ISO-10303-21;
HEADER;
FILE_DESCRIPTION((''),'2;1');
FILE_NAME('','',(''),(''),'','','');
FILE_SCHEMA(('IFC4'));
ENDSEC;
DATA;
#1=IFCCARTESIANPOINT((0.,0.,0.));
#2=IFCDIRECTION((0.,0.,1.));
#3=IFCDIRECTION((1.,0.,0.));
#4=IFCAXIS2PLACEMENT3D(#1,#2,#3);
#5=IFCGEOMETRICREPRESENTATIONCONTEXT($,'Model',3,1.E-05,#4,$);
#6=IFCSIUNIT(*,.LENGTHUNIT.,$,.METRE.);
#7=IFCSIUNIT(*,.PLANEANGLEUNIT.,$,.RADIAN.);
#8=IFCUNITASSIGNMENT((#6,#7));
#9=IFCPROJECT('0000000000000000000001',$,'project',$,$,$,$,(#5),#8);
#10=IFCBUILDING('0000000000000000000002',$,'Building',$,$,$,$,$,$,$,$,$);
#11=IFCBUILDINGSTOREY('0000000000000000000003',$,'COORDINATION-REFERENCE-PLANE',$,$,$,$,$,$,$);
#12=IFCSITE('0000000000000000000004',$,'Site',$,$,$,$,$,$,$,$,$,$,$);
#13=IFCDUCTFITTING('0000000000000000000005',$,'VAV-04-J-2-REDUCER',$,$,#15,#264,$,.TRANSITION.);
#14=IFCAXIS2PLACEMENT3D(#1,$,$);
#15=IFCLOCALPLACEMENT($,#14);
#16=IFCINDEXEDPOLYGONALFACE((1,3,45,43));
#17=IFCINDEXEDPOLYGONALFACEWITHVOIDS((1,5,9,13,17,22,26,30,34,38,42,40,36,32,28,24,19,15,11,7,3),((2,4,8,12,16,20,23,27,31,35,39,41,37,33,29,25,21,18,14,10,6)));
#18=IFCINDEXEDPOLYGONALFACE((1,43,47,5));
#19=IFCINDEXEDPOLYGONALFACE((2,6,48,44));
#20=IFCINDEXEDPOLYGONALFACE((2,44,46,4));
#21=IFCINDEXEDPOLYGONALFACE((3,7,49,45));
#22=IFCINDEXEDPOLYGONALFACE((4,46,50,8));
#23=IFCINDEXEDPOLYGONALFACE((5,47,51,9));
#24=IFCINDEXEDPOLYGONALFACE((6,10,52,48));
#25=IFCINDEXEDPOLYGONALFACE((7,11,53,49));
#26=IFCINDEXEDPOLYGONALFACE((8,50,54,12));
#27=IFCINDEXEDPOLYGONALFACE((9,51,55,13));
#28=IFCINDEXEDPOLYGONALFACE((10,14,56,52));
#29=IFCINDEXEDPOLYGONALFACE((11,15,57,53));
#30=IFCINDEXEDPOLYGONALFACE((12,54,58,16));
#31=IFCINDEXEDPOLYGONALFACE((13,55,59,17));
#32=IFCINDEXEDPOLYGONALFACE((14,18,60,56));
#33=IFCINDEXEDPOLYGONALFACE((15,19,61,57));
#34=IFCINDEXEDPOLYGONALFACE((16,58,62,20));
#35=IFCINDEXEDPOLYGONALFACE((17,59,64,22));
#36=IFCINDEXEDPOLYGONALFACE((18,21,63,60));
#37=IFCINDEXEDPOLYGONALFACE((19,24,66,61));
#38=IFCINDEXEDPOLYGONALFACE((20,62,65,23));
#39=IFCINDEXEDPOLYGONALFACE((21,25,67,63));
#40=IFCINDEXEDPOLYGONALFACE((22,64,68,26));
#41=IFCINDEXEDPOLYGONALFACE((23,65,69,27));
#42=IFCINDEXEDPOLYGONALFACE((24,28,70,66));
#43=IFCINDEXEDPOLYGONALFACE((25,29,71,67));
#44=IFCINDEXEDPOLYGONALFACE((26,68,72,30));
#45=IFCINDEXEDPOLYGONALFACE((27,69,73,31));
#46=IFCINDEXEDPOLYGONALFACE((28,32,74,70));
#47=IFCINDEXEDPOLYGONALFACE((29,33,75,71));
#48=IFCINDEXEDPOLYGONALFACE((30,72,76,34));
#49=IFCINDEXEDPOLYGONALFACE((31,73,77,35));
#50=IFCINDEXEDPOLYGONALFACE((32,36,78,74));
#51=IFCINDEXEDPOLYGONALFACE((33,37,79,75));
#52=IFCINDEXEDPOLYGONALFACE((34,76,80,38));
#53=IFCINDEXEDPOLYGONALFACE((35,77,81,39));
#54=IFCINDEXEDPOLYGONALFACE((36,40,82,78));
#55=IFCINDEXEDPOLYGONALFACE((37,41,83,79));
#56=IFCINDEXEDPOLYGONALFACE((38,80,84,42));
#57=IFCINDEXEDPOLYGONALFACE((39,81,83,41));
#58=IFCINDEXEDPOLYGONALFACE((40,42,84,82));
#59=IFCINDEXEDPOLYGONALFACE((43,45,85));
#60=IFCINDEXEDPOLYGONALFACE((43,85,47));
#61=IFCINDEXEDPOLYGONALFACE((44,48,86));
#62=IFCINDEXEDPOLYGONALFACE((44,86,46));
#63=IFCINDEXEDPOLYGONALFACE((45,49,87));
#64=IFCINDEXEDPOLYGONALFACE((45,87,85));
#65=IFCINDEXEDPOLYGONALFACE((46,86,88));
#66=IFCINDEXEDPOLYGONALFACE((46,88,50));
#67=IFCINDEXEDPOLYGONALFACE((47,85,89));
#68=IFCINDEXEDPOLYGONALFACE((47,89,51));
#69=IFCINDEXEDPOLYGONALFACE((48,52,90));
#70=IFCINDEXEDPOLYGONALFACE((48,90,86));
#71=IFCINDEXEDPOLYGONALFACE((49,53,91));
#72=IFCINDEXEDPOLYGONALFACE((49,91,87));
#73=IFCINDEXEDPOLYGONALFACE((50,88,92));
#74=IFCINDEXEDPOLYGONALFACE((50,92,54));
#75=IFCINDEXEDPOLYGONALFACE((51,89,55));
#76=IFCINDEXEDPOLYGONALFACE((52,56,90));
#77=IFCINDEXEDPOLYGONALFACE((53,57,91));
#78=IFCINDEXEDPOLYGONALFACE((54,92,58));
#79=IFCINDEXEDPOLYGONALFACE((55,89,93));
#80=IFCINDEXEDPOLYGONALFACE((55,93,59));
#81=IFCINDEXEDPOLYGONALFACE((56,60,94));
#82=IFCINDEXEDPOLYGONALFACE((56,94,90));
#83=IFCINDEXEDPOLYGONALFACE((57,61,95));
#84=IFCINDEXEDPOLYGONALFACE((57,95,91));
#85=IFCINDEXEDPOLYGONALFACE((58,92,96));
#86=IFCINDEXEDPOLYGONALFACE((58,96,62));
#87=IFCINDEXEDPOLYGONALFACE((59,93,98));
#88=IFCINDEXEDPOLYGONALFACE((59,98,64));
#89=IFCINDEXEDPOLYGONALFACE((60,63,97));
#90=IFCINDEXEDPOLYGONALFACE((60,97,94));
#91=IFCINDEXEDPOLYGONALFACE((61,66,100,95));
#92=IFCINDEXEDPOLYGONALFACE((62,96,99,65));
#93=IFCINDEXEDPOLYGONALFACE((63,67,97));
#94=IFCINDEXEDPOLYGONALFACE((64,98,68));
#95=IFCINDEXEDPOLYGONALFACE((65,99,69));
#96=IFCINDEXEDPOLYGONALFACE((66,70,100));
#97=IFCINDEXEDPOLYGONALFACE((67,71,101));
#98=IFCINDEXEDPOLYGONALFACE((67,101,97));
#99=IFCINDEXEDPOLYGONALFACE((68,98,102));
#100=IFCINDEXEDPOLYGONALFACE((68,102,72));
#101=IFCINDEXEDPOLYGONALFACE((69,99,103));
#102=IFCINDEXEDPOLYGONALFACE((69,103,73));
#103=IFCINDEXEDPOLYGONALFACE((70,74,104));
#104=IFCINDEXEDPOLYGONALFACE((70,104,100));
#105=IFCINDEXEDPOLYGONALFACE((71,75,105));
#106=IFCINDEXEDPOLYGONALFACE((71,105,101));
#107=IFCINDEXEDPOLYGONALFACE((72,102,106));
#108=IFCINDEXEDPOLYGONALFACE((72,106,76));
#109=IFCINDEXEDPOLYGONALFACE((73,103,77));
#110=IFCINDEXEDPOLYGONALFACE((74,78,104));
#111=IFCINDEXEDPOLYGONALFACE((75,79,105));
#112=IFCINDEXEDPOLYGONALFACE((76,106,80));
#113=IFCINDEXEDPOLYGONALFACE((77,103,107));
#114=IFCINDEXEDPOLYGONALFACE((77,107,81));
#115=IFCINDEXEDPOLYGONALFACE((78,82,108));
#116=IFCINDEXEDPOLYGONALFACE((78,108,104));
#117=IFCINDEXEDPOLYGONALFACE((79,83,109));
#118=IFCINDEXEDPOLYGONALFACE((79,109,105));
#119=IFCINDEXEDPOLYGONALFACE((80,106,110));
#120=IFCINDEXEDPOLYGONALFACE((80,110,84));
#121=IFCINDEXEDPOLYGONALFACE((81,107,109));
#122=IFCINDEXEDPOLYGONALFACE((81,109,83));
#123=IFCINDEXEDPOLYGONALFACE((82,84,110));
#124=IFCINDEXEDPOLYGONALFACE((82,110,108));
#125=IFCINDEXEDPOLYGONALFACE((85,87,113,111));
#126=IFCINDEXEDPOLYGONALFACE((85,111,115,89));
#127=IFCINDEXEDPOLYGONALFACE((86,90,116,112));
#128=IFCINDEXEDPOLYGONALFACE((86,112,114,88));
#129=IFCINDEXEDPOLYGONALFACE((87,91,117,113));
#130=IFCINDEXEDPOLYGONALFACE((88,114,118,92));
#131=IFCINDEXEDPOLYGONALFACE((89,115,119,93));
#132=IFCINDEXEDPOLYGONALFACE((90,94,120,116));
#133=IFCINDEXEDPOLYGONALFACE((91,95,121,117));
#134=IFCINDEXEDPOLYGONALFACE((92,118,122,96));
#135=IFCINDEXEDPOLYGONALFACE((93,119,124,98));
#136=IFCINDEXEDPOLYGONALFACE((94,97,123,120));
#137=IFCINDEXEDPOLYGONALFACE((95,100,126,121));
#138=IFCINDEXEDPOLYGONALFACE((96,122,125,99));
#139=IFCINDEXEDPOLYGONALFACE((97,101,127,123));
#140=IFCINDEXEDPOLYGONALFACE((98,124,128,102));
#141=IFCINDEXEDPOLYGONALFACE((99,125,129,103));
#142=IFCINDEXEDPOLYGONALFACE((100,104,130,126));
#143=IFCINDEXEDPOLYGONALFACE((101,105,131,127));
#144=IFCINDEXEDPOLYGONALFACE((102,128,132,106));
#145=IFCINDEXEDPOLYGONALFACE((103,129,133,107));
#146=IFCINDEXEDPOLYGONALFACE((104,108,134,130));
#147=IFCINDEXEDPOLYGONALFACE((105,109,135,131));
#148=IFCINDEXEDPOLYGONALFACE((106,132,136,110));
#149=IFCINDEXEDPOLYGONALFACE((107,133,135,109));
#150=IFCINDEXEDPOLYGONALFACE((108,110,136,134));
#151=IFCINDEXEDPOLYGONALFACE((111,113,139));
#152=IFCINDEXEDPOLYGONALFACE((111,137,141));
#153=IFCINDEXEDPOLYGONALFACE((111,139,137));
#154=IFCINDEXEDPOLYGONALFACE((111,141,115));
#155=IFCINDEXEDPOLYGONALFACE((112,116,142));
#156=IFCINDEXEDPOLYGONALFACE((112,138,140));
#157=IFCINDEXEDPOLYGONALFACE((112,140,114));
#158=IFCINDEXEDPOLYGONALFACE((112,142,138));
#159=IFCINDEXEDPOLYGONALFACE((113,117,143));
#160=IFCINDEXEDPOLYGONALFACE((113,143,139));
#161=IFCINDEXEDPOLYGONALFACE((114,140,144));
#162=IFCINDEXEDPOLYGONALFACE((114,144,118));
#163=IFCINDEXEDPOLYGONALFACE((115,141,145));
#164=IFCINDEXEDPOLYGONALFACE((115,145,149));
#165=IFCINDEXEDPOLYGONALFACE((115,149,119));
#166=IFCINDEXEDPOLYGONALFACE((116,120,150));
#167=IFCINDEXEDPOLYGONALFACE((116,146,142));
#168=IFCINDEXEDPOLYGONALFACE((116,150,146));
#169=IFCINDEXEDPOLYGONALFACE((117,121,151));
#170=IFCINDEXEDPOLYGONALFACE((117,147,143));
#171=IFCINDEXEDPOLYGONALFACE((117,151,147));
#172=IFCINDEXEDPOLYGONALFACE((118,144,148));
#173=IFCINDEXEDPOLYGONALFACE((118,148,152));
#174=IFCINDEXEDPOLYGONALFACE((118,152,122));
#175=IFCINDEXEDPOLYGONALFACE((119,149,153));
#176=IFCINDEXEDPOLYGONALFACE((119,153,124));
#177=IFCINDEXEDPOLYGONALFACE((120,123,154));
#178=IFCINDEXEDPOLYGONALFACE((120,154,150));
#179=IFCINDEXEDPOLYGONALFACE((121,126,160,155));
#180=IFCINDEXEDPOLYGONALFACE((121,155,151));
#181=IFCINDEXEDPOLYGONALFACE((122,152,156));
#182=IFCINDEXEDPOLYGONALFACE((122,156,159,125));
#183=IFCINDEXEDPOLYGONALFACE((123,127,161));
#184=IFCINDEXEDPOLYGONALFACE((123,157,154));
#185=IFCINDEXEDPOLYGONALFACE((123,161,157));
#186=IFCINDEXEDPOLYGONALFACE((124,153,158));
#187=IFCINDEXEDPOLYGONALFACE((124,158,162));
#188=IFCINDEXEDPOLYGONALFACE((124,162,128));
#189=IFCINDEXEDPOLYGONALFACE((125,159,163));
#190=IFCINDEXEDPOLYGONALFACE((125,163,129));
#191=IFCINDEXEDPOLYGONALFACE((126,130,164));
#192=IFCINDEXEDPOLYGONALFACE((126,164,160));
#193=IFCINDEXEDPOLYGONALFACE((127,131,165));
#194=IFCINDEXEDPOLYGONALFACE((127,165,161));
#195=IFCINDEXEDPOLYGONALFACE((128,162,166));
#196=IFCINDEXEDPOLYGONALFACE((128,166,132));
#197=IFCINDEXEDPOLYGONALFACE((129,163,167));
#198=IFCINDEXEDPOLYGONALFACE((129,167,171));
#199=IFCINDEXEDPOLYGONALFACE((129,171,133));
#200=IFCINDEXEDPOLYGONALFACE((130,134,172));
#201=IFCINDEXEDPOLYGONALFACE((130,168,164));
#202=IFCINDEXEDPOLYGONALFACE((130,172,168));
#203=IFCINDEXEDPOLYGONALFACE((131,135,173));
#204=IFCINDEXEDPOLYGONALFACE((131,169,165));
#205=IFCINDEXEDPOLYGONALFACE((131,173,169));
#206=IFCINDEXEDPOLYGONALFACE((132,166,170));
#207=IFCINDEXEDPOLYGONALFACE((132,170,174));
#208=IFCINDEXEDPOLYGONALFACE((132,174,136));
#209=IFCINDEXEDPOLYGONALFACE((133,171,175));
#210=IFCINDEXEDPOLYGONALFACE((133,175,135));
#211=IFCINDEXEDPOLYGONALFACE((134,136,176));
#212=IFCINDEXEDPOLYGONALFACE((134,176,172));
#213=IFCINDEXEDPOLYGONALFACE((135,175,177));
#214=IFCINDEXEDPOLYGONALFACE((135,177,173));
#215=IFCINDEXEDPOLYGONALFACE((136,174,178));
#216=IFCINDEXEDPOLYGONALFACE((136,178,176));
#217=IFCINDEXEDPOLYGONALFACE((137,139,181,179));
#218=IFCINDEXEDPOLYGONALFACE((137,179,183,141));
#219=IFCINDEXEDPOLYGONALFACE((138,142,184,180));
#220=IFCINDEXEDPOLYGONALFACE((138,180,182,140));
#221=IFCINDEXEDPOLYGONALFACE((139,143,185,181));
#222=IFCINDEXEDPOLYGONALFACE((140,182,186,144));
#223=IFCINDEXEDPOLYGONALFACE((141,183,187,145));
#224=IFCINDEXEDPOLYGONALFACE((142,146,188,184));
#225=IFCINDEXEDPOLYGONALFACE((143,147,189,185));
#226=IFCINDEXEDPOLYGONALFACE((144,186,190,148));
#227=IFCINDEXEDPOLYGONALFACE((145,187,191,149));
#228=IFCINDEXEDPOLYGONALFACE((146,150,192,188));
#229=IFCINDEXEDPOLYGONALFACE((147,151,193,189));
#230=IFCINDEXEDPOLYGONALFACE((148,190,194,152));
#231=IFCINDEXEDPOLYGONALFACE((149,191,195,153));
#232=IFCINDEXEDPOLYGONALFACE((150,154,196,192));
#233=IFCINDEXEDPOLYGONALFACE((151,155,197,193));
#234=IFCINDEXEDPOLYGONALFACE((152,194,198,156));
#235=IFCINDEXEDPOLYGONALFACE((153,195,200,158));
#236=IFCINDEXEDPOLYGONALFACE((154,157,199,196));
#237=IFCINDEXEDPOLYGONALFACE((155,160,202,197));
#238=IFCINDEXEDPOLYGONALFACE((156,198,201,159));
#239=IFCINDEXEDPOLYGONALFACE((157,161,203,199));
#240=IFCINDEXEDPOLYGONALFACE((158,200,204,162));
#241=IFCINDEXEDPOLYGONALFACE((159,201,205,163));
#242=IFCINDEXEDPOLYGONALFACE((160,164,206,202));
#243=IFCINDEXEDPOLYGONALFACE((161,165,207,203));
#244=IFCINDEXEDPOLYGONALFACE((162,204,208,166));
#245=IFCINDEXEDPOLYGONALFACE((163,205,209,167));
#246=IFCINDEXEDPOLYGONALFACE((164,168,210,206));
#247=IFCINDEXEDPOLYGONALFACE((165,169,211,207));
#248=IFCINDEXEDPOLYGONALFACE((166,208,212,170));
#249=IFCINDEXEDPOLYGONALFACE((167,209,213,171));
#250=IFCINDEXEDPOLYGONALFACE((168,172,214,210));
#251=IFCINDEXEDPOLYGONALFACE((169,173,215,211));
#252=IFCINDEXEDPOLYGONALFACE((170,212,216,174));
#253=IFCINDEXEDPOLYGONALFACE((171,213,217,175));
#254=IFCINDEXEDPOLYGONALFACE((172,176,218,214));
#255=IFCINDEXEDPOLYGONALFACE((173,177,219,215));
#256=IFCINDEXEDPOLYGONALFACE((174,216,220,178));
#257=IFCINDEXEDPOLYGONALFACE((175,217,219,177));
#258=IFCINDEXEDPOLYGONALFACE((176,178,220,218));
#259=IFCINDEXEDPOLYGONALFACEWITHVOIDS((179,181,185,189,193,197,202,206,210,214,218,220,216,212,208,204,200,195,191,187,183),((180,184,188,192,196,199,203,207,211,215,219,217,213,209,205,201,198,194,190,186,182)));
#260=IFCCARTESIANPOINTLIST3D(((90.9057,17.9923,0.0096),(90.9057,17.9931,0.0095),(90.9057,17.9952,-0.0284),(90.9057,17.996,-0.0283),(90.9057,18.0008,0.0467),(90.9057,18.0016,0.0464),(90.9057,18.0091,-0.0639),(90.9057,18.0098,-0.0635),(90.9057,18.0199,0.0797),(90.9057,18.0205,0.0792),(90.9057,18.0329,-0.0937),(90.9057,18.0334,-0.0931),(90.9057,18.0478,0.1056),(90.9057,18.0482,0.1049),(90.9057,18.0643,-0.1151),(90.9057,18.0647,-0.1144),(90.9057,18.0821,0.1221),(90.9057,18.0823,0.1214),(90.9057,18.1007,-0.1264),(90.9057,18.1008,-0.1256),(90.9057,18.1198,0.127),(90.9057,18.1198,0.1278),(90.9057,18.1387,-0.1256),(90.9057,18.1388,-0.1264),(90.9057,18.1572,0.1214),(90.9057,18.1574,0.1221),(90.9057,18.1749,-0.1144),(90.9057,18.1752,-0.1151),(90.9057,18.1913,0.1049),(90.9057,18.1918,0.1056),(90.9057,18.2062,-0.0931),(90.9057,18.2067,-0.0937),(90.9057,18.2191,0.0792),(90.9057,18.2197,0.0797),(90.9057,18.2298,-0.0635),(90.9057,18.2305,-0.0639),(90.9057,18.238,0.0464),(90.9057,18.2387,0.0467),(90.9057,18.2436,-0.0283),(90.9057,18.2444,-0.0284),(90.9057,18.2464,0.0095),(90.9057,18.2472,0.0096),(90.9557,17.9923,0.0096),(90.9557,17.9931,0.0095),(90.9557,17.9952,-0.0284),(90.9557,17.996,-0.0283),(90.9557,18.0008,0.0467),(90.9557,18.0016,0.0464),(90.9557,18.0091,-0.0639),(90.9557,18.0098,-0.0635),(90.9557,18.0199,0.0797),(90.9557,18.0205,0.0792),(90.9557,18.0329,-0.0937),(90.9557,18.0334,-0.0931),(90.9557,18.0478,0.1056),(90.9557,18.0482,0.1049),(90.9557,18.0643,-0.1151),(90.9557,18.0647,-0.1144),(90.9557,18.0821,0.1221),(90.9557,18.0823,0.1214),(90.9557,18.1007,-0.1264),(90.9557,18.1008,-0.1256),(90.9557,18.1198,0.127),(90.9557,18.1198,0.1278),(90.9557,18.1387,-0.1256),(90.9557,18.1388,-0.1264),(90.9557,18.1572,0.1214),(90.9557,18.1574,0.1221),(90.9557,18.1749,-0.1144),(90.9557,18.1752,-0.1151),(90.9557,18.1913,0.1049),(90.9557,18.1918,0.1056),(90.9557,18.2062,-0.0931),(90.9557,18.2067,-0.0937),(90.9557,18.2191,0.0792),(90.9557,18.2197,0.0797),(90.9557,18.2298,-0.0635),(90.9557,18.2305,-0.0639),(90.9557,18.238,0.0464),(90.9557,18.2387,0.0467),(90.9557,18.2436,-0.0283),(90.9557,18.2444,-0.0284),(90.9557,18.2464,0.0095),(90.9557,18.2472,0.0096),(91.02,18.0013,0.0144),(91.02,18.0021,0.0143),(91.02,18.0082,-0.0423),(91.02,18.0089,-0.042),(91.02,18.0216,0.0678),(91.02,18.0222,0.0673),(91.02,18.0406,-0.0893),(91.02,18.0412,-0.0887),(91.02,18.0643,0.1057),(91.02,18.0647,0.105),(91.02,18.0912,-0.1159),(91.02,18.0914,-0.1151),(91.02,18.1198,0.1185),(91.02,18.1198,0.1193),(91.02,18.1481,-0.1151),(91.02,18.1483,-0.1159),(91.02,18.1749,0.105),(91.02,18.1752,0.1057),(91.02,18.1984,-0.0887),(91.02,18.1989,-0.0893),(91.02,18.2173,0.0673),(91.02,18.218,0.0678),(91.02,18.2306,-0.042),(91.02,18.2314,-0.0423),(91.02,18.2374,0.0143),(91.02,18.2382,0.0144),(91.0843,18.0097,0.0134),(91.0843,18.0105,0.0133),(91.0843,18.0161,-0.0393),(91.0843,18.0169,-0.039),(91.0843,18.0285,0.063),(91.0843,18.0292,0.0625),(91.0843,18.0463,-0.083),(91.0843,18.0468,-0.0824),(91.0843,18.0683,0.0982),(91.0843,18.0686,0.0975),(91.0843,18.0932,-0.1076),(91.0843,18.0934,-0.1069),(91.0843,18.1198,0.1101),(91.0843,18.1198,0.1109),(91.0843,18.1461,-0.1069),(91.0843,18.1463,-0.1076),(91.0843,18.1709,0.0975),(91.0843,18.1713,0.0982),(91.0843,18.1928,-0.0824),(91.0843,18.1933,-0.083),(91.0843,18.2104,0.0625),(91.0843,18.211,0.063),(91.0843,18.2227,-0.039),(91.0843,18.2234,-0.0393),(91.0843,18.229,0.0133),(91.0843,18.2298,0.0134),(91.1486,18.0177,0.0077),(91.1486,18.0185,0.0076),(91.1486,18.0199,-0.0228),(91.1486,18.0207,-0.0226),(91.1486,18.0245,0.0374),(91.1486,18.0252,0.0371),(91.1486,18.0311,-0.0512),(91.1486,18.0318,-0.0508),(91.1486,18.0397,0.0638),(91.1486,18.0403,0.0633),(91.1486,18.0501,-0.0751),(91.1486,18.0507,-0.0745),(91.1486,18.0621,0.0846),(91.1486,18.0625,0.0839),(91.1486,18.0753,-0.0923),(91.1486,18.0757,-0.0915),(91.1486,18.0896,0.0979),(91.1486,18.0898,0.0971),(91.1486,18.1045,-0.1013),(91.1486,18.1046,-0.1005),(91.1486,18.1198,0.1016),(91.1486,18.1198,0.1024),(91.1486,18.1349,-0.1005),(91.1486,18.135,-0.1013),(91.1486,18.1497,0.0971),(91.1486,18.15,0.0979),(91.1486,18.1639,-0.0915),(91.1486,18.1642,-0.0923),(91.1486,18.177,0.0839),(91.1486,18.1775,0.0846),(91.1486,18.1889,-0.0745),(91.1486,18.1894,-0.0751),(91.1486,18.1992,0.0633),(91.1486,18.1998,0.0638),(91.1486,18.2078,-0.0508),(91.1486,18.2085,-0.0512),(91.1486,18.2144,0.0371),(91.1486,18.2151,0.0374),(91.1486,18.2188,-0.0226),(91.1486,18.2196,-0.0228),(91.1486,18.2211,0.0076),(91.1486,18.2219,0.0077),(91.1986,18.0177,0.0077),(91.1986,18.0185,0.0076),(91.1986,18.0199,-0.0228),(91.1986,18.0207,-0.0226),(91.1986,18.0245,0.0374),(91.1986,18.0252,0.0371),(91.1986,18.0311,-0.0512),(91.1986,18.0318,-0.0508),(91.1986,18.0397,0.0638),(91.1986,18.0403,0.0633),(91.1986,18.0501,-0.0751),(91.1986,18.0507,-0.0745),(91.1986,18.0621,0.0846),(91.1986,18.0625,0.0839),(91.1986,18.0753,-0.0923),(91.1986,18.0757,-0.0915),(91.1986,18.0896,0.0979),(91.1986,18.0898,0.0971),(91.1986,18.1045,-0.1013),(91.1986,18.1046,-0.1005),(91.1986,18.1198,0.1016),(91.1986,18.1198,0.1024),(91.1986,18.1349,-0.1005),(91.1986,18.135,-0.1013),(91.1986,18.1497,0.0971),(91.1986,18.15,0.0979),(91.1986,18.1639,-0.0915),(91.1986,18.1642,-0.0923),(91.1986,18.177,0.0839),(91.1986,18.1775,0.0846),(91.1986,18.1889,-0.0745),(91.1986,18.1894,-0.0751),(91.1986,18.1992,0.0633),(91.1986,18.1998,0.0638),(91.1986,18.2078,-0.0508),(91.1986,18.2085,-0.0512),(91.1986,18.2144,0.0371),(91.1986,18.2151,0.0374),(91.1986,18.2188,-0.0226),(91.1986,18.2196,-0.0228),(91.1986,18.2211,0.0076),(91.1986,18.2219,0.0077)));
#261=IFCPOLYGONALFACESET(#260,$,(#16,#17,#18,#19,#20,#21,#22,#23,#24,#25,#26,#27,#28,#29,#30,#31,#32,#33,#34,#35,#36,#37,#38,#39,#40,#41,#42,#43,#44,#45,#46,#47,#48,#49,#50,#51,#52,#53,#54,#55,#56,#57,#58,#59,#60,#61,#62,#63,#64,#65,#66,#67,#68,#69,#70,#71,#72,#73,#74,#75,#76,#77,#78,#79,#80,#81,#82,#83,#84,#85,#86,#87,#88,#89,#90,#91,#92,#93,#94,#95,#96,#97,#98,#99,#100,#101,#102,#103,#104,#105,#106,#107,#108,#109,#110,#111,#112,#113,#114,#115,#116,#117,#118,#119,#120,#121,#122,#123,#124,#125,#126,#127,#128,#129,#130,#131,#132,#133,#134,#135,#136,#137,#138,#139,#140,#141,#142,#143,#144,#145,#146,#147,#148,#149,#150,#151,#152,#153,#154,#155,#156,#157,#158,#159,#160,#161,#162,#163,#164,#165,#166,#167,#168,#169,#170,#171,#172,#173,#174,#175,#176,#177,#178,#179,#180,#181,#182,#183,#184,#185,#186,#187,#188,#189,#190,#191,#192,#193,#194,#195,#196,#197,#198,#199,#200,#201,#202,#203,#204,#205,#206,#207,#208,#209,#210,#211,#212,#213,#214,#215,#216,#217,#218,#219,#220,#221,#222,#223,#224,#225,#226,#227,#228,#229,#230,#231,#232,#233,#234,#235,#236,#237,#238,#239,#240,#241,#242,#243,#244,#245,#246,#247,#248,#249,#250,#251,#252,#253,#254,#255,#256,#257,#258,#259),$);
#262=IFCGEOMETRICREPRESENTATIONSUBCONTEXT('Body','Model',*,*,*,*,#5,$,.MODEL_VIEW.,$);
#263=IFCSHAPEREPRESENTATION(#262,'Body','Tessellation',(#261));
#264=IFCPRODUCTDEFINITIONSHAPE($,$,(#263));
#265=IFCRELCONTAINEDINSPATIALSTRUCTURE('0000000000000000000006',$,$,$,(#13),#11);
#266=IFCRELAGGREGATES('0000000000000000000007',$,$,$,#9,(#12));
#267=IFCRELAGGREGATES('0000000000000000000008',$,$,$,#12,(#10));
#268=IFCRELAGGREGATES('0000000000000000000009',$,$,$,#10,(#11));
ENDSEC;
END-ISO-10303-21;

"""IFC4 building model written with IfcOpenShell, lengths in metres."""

from ifc_helpers import new_model, entity, si_unit, frame, origin_with_axes, place, context, subcontext, project, spatial, element, save


model = new_model("IFC4")

# Units and contexts
model_context_1 = context("Model", 3, precision=1e-05, world=origin_with_axes())
body_context_1 = subcontext(model_context_1, "Body", "Model", "MODEL_VIEW")
ifc_project = project(units=[si_unit("LENGTHUNIT", "METRE"), si_unit("PLANEANGLEUNIT", "RADIAN")], contexts=[model_context_1])

# Site, building, storey
site = spatial("IfcSite", under=ifc_project, Name="Site")
building = spatial("IfcBuilding", under=site, Name="Building")
storey = spatial("IfcBuildingStorey", under=building, Name="COORDINATION-REFERENCE-PLANE")

# Duct fitting
for number, where, z_axis, x_axis, name in (
    (1, (90.9057, 18.1198, 0.0), (0.0, 1.0, 0.0), (0.0, 0.0, 1.0), "VAV-04-J-2-REDUCER"),
):
    element("IfcDuctFitting", number, at=place(None, frame(where, z_axis=z_axis, x_axis=x_axis)), inside=storey, Name=name, PredefinedType="TRANSITION", context=body_context_1, shape_type="SweptSolid", body=[
        entity("IfcRevolvedAreaSolid", entity("IfcArbitraryClosedProfileDef", "AREA", None, entity("IfcPolyline", [entity("IfcCartesianPoint", [0.1278, 0.0]), entity("IfcCartesianPoint", [0.1278, 0.05]), entity("IfcCartesianPoint", [0.1024, 0.2429]), entity("IfcCartesianPoint", [0.1024, 0.2929]), entity("IfcCartesianPoint", [0.1016, 0.2929]), entity("IfcCartesianPoint", [0.1016, 0.2429]), entity("IfcCartesianPoint", [0.127, 0.05]), entity("IfcCartesianPoint", [0.127, 0.0]), entity("IfcCartesianPoint", [0.1278, 0.0])])), entity("IfcAxis2Placement3D", entity("IfcCartesianPoint", [0.0, 0.0, 0.0])), entity("IfcAxis1Placement", entity("IfcCartesianPoint", [0.0, 0.0, 0.0]), entity("IfcDirection", [0.0, 1.0, 0.0])), 6.283185),
    ])

save(model, "model.ifc")
